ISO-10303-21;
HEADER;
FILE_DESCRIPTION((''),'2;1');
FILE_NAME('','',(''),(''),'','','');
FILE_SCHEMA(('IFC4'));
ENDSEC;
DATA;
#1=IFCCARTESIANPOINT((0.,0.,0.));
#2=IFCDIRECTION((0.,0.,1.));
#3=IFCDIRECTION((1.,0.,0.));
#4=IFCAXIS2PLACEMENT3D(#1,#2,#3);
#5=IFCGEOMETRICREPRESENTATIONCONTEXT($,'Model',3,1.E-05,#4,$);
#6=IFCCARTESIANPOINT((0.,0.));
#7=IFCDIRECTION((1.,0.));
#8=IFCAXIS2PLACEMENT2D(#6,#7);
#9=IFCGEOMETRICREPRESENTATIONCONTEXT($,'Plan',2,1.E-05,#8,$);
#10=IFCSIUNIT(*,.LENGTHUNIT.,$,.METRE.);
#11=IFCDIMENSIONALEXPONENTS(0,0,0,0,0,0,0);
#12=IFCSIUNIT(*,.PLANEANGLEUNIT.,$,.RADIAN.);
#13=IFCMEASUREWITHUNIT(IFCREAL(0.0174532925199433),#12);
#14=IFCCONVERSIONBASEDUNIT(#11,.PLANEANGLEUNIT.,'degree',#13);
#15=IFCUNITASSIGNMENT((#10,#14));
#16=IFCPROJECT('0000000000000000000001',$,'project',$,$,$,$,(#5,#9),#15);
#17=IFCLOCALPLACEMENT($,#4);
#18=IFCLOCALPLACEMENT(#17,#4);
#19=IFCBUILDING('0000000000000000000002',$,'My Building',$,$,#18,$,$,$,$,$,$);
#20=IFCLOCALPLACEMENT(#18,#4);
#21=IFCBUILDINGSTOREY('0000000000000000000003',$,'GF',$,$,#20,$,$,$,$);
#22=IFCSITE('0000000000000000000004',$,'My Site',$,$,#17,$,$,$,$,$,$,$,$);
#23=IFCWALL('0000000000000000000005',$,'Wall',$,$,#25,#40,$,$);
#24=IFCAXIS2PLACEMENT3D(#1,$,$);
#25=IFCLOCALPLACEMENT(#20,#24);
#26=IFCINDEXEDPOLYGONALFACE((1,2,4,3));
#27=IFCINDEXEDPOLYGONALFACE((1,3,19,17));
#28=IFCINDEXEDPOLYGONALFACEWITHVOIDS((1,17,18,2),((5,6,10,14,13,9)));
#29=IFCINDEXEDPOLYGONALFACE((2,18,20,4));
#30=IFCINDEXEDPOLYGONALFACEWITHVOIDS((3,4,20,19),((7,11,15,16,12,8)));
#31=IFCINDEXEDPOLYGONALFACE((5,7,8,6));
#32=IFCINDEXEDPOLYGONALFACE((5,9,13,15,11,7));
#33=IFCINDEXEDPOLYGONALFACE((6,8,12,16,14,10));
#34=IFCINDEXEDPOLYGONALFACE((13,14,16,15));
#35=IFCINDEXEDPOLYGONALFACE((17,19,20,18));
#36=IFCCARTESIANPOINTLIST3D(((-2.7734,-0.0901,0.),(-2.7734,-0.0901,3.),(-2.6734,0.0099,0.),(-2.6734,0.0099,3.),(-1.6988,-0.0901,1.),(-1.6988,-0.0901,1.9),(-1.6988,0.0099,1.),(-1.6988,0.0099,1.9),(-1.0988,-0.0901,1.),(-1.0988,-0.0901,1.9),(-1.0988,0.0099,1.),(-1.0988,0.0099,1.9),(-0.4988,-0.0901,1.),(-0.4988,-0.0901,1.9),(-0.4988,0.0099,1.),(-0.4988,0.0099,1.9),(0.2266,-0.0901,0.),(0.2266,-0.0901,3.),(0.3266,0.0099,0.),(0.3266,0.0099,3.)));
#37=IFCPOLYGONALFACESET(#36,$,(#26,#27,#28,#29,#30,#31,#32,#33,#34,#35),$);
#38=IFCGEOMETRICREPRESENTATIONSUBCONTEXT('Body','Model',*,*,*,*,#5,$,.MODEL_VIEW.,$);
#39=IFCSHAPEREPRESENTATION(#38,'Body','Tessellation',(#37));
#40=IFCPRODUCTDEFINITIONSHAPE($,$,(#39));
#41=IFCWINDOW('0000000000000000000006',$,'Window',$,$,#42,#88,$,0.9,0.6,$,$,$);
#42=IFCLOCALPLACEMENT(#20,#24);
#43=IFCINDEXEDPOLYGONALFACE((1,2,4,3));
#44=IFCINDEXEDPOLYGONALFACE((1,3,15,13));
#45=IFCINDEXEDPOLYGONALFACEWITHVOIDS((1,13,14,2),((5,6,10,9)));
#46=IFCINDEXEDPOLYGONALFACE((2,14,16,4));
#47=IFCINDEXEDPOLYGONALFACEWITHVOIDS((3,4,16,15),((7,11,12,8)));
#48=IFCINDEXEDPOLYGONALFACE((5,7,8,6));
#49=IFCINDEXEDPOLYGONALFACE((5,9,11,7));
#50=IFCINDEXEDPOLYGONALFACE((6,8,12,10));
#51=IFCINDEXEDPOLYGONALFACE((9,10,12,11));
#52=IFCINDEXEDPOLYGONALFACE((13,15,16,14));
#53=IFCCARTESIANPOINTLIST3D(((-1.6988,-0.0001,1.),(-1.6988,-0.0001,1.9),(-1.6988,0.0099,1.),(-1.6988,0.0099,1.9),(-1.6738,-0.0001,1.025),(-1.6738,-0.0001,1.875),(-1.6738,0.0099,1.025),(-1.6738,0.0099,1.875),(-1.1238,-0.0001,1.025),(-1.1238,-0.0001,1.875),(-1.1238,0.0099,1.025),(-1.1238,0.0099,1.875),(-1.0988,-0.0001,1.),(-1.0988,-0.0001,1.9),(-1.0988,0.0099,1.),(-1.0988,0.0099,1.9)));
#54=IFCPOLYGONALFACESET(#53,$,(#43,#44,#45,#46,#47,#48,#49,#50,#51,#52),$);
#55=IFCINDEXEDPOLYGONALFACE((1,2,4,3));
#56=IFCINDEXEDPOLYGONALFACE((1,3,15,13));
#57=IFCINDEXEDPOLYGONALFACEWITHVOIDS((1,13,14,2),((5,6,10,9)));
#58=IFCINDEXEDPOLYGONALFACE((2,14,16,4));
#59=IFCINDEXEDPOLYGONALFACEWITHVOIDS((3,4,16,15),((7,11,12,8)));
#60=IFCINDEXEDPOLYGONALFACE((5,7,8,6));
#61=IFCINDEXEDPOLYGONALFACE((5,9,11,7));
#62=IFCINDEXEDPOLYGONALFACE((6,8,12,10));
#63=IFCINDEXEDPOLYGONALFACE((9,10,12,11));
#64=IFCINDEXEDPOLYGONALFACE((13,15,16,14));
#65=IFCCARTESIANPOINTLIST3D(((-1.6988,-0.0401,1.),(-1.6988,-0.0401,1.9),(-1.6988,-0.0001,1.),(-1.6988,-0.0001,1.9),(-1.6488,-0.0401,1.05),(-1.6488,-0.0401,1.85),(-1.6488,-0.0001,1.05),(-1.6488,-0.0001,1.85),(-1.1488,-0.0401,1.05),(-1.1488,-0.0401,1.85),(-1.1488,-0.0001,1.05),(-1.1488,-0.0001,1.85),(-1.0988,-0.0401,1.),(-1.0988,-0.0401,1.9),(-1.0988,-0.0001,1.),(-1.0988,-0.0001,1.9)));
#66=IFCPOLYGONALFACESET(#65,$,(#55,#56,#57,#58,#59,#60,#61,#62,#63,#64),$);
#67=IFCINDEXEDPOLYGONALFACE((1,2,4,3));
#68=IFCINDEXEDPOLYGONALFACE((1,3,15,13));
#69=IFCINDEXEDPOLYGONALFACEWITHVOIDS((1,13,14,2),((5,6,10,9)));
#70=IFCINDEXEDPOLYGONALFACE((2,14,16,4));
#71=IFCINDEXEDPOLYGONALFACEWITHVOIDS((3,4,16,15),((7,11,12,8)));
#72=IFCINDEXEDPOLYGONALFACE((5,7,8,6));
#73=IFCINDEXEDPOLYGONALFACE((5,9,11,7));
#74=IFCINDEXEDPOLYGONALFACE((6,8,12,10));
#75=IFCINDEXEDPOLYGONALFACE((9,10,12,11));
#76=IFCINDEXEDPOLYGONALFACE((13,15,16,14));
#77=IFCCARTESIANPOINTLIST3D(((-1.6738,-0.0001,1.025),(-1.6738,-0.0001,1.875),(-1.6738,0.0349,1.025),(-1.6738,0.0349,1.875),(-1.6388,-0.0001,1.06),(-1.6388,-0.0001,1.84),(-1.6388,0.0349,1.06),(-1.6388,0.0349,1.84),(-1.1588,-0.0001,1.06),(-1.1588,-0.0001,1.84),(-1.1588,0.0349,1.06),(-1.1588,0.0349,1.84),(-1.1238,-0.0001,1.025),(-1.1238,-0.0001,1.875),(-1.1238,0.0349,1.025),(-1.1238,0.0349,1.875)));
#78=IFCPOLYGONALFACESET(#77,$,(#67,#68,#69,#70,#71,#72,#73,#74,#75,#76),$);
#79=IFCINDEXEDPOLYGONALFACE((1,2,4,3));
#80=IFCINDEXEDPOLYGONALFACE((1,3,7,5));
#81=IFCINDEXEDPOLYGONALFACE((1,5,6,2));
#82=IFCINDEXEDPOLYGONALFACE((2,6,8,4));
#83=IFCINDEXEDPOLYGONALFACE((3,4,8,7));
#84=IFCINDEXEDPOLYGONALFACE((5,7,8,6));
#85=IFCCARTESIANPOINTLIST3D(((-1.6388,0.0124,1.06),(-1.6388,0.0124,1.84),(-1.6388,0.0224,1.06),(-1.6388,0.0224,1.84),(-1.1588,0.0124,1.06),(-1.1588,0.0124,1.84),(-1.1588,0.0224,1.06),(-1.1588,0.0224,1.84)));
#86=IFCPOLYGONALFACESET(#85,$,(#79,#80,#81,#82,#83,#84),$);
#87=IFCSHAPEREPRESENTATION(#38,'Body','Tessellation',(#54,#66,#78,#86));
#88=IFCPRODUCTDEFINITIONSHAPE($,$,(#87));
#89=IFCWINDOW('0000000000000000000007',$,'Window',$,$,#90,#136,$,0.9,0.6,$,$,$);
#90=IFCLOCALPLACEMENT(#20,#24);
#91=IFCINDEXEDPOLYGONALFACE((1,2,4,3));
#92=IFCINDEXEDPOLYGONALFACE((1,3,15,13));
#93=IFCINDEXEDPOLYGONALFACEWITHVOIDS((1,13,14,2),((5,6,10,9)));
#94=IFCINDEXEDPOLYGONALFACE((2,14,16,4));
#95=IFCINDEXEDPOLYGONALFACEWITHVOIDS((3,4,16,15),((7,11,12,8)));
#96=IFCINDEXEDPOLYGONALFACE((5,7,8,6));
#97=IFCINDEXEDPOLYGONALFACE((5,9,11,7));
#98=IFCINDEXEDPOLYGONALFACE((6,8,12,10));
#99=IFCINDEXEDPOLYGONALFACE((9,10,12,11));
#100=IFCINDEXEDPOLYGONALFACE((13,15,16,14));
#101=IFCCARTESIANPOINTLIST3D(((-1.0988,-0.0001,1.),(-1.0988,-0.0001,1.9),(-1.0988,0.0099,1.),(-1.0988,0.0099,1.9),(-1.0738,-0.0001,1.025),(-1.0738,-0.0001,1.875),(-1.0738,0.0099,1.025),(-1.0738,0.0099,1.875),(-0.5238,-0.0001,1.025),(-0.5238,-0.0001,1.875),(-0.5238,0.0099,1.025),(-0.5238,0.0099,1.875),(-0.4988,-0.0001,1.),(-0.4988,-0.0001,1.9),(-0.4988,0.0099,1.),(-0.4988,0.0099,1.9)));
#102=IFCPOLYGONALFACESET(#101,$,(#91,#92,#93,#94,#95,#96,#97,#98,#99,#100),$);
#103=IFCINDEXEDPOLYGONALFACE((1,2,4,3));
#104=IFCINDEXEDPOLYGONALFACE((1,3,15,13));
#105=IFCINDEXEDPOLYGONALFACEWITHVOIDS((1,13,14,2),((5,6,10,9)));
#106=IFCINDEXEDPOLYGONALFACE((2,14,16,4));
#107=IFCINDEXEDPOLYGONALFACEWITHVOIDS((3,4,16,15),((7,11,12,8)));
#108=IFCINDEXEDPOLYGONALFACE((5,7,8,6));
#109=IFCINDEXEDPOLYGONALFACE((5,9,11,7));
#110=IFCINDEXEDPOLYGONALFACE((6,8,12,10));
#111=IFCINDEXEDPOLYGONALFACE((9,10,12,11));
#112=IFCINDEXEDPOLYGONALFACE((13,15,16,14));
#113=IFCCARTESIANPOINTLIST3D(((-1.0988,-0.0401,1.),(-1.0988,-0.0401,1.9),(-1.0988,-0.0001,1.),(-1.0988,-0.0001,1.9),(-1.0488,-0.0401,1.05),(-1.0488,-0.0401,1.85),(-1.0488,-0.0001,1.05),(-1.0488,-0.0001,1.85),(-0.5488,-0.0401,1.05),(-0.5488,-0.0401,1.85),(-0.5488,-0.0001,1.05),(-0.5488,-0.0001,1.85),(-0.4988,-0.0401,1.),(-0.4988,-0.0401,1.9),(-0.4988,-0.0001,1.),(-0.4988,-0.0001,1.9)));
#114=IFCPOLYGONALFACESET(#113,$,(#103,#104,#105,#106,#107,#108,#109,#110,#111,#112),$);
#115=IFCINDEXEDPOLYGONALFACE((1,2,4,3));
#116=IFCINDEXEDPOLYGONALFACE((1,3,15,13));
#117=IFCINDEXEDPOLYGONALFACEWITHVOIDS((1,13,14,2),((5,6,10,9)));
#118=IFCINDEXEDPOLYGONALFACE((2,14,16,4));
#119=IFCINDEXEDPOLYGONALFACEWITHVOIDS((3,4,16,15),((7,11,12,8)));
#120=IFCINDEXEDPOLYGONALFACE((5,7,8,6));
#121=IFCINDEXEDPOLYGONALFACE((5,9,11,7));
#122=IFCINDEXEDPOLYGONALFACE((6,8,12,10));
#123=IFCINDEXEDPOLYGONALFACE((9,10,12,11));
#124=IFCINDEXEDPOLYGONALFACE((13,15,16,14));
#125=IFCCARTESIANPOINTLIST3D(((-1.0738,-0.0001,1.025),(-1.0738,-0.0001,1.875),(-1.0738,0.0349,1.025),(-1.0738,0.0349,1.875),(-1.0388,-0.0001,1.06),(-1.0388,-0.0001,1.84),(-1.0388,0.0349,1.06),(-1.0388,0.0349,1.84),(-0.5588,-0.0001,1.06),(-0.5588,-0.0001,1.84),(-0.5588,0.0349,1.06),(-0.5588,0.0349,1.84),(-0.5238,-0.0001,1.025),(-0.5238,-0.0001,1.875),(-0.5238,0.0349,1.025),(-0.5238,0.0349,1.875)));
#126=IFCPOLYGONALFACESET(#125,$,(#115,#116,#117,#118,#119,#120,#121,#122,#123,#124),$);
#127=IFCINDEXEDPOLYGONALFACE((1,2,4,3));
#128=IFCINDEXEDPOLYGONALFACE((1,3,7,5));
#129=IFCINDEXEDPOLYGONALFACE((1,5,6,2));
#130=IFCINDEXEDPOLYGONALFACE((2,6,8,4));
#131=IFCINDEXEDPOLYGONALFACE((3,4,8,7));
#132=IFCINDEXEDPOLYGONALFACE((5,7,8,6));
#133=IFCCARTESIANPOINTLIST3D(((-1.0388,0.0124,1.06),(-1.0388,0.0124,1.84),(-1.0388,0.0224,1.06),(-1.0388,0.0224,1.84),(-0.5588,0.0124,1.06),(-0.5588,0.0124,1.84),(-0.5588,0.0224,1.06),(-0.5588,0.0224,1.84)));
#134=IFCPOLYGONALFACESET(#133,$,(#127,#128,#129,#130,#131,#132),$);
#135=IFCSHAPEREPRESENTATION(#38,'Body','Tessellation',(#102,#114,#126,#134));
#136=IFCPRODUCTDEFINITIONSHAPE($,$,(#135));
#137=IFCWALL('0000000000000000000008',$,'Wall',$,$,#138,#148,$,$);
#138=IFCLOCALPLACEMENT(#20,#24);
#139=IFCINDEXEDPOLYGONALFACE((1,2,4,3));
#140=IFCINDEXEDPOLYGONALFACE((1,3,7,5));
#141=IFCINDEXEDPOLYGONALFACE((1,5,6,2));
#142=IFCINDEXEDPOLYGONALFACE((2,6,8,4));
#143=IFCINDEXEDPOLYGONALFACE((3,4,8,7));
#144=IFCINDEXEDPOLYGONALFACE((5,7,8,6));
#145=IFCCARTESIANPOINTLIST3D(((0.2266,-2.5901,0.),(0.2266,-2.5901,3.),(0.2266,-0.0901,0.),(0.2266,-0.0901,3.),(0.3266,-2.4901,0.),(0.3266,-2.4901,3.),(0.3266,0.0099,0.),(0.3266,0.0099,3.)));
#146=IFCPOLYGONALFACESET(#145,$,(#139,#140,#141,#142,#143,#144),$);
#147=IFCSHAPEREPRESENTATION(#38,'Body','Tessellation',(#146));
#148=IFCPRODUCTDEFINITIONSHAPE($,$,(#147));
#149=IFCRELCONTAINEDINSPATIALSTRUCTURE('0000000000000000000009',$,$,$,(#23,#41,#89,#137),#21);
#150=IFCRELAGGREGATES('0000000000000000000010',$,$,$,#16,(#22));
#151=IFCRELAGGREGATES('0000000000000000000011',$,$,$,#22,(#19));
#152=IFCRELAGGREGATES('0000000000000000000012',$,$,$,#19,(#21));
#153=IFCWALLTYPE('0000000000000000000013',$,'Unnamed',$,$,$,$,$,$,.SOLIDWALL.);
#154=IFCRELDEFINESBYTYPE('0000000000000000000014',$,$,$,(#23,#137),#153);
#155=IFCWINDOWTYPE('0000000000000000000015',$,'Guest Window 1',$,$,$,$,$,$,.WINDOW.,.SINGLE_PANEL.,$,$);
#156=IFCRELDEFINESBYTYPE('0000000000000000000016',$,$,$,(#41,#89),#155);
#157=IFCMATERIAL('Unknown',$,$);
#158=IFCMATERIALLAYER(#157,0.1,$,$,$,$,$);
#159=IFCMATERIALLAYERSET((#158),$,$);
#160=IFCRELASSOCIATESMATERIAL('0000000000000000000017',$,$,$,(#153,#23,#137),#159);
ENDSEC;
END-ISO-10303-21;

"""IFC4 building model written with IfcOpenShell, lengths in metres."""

from ifc_helpers import new_model, entity, si_unit, converted_unit, frame, origin_with_axes, origin_2d_with_axis, place, context, subcontext, project, spatial, line, indexed_curve, outline, extrude, shape, source, transform, mapped, material, layer, layer_set, layer_usage, type_object, type_shapes, element, fill, save


model = new_model("IFC4")

# Units and contexts
model_context = context("Model", 3, precision=1e-05, world=origin_with_axes())
plan_context = context("Plan", 2, precision=1e-05, world=origin_2d_with_axis())
body_context_1 = subcontext(model_context, "Body", "Model", "MODEL_VIEW")
body_context_2 = subcontext(plan_context, "Body", "Plan", "PLAN_VIEW")
ifc_project = project(units=[si_unit("LENGTHUNIT", "METRE"), converted_unit("PLANEANGLEUNIT", "degree", entity("IfcReal", 0.0174532925199433), si_unit("PLANEANGLEUNIT", "RADIAN"), dimensions=[0, 0, 0, 0, 0, 0, 0])], contexts=[model_context, plan_context])

# Site, building, storey
site_placement = place(None, origin_with_axes())
site = spatial("IfcSite", under=ifc_project, at=site_placement, Name="My Site")
building_placement = place(site_placement, origin_with_axes())
building = spatial("IfcBuilding", under=site, at=building_placement, Name="My Building")
storey_placement = place(building_placement, origin_with_axes())
storey = spatial("IfcBuildingStorey", under=building, at=storey_placement, Name="GF")

# Shared definitions
ifc_material_1 = material(Name="Unknown")

# Shared definitions
ifc_layer_1 = layer(ifc_material_1, 0.1)
ifc_layer_set_1 = layer_set([ifc_layer_1])
wall_type = type_object("IfcWallType", Name="Unnamed", PredefinedType="SOLIDWALL", material=ifc_layer_set_1)

# Wall, openings, windows
ifc_layer_usage_1 = layer_usage(ifc_layer_set_1, "AXIS2", "POSITIVE", 0.0)
wall_1_placement = place(storey_placement, frame((-2.7734, -0.0901, 0.0), z_axis=(0.0, 0.0, 1.0), x_axis=(1.0, 0.0, 0.0)))
wall_1 = element("IfcWall", 1, at=wall_1_placement, inside=storey, type_object=wall_type, material=ifc_layer_usage_1, Name="Wall", context=body_context_1, shape_type="SweptSolid", body=[
    extrude(outline(indexed_curve([(0.0, 0.0), (0.1, 0.1), (3.1, 0.1), (3.0, 0.0)], segments=[line(1, 2, 3, 4, 1)])), origin_with_axes(), (0.0, 0.0, 1.0), 3.0),
])
shared_shape_1 = source(origin_with_axes(), body_context_1, "Body", "SweptSolid", [
    extrude(outline(indexed_curve([(0.0, 0.0), (0.6, 0.0), (0.6, 0.9), (0.0, 0.9)], segments=[line(1, 2, 3, 4, 1)])), frame((0.0, -0.6, 0.0), z_axis=(0.0, -1.0, 0.0), x_axis=(1.0, 0.0, 0.0)), (0.0, 0.0, -1.0), 1.2),
])
opening_1_placement = place(wall_1_placement, frame((1.0746, 0.0, 1.0), z_axis=(0.0, 0.0, 1.0), x_axis=(1.0, 0.0, 0.0)))
opening_1 = element("IfcOpeningElement", 2, at=opening_1_placement, cuts=wall_1, PredefinedType="OPENING", context=body_context_1, shape_type="MappedRepresentation", body=[
    mapped(shared_shape_1, transform((0.0, 0.0, 0.0), x_axis=(1.0, 0.0, 0.0), y_axis=(0.0, 1.0, 0.0), z_axis=(0.0, 0.0, 1.0), scale=1.0)),
])
opening_2_placement = place(wall_1_placement, frame((1.6746, 0.0, 1.0), z_axis=(0.0, 0.0, 1.0), x_axis=(1.0, 0.0, 0.0)))
opening_2 = element("IfcOpeningElement", 3, at=opening_2_placement, cuts=wall_1, PredefinedType="OPENING", context=body_context_1, shape_type="MappedRepresentation", body=[
    mapped(shared_shape_1, transform((0.0, 0.0, 0.0), x_axis=(1.0, 0.0, 0.0), y_axis=(0.0, 1.0, 0.0), z_axis=(0.0, 0.0, 1.0), scale=1.0)),
])
window_type_1 = type_object("IfcWindowType", Name="Guest Window 1", PartitioningType="SINGLE_PANEL", PredefinedType="WINDOW")
shared_shape_2 = source(origin_with_axes(), body_context_1, "Body", "SweptSolid", [
    extrude(outline(indexed_curve([(0.0, 0.0), (0.6, 0.0), (0.6, 0.9), (0.0, 0.9)], segments=[line(1, 2, 3, 4, 1)]), holes=[indexed_curve([(0.025, 0.025), (0.575, 0.025), (0.575, 0.875), (0.025, 0.875)], segments=[line(1, 2, 3, 4, 1)])]), frame((0.0, 0.09, 0.0), z_axis=(0.0, -1.0, 0.0), x_axis=(1.0, 0.0, 0.0)), (0.0, 0.0, -1.0), 0.01),
    extrude(outline(indexed_curve([(0.0, 0.0), (0.6, 0.0), (0.6, 0.9), (0.0, 0.9)], segments=[line(1, 2, 3, 4, 1)]), holes=[indexed_curve([(0.05, 0.05), (0.55, 0.05), (0.55, 0.85), (0.05, 0.85)], segments=[line(1, 2, 3, 4, 1)])]), frame((0.0, 0.05, 0.0), z_axis=(0.0, -1.0, 0.0), x_axis=(1.0, 0.0, 0.0)), (0.0, 0.0, -1.0), 0.04),
    extrude(outline(indexed_curve([(0.0, 0.0), (0.55, 0.0), (0.55, 0.85), (0.0, 0.85)], segments=[line(1, 2, 3, 4, 1)]), holes=[indexed_curve([(0.035, 0.035), (0.515, 0.035), (0.515, 0.815), (0.035, 0.815)], segments=[line(1, 2, 3, 4, 1)])]), frame((0.025, 0.09, 0.025), z_axis=(0.0, -1.0, 0.0), x_axis=(1.0, 0.0, 0.0)), (0.0, 0.0, -1.0), 0.035),
    extrude(outline(indexed_curve([(0.035, 0.035), (0.515, 0.035), (0.515, 0.815), (0.035, 0.815)], segments=[line(1, 2, 3, 4, 1)])), frame((0.025, 0.1025, 0.025), z_axis=(0.0, -1.0, 0.0), x_axis=(1.0, 0.0, 0.0)), (0.0, 0.0, -1.0), 0.01),
])
shared_shape_3 = source(origin_with_axes(), body_context_2, "Body", "Curve2D", [
    entity("IfcIndexedPolyCurve", entity("IfcCartesianPointList2D", [[0.05, 0.05], [0.55, 0.05]])),
    entity("IfcIndexedPolyCurve", entity("IfcCartesianPointList2D", [[0.0, 0.1], [0.025, 0.1], [0.025, 0.09], [0.05, 0.09], [0.05, 0.05], [0.0, 0.05]]), [entity("IfcLineIndex", [1, 2, 3, 4, 5, 6, 1])]),
    entity("IfcIndexedPolyCurve", entity("IfcCartesianPointList2D", [[0.6, 0.1], [0.575, 0.1], [0.575, 0.09], [0.55, 0.09], [0.55, 0.05], [0.6, 0.05]]), [entity("IfcLineIndex", [1, 2, 3, 4, 5, 6, 1])]),
    entity("IfcIndexedPolyCurve", entity("IfcCartesianPointList2D", [[0.025, 0.09], [0.06, 0.09], [0.06, 0.125], [0.025, 0.125]]), [entity("IfcLineIndex", [1, 2, 3, 4, 1])]),
    entity("IfcIndexedPolyCurve", entity("IfcCartesianPointList2D", [[0.575, 0.09], [0.54, 0.09], [0.54, 0.125], [0.575, 0.125]]), [entity("IfcLineIndex", [1, 2, 3, 4, 1])]),
    entity("IfcIndexedPolyCurve", entity("IfcCartesianPointList2D", [[0.06, 0.09], [0.54, 0.09]])),
    entity("IfcIndexedPolyCurve", entity("IfcCartesianPointList2D", [[0.06, 0.125], [0.54, 0.125]])),
    entity("IfcIndexedPolyCurve", entity("IfcCartesianPointList2D", [[0.06, 0.1075], [0.54, 0.1075]])),
])
type_shapes(window_type_1, [shared_shape_2, shared_shape_3])
window_1_placement = place(opening_1_placement, origin_with_axes())
window_1 = element("IfcWindow", 4, at=window_1_placement, inside=storey, type_object=window_type_1, Name="Window", OverallHeight=0.9, OverallWidth=0.6, shapes=[
    shape(body_context_1, "Body", "MappedRepresentation", [mapped(shared_shape_2, transform((0.0, 0.0, 0.0), x_axis=(1.0, 0.0, 0.0), y_axis=(0.0, 1.0, 0.0), z_axis=(0.0, 0.0, 1.0), scale=1.0))]),
    shape(body_context_2, "Body", "MappedRepresentation", [mapped(shared_shape_3, transform((0.0, 0.0, 0.0), x_axis=(1.0, 0.0, 0.0), y_axis=(0.0, 1.0, 0.0), z_axis=(0.0, 0.0, 1.0), scale=1.0))]),
])
fill(opening_1, window_1)
window_2_placement = place(opening_2_placement, origin_with_axes())
window_2 = element("IfcWindow", 5, at=window_2_placement, inside=storey, type_object=window_type_1, Name="Window", OverallHeight=0.9, OverallWidth=0.6, shapes=[
    shape(body_context_1, "Body", "MappedRepresentation", [mapped(shared_shape_2, transform((0.0, 0.0, 0.0), x_axis=(1.0, 0.0, 0.0), y_axis=(0.0, 1.0, 0.0), z_axis=(0.0, 0.0, 1.0), scale=1.0))]),
    shape(body_context_2, "Body", "MappedRepresentation", [mapped(shared_shape_3, transform((0.0, 0.0, 0.0), x_axis=(1.0, 0.0, 0.0), y_axis=(0.0, 1.0, 0.0), z_axis=(0.0, 0.0, 1.0), scale=1.0))]),
])
fill(opening_2, window_2)

# Wall
ifc_layer_usage_2 = layer_usage(ifc_layer_set_1, "AXIS2", "POSITIVE", 0.0)
wall_2_placement = place(storey_placement, frame((0.2266, -0.0901, 0.0), z_axis=(0.0, 0.0, 1.0), x_axis=(0.0, -1.0, 0.0)))
element("IfcWall", 6, at=wall_2_placement, inside=storey, type_object=wall_type, material=ifc_layer_usage_2, Name="Wall", context=body_context_1, shape_type="SweptSolid", body=[
    extrude(outline(indexed_curve([(0.0, 0.0), (-0.1, 0.1), (2.4, 0.1), (2.5, 0.0)], segments=[line(1, 2, 3, 4, 1)])), origin_with_axes(), (0.0, 0.0, 1.0), 3.0),
])

save(model, "model.ifc")
